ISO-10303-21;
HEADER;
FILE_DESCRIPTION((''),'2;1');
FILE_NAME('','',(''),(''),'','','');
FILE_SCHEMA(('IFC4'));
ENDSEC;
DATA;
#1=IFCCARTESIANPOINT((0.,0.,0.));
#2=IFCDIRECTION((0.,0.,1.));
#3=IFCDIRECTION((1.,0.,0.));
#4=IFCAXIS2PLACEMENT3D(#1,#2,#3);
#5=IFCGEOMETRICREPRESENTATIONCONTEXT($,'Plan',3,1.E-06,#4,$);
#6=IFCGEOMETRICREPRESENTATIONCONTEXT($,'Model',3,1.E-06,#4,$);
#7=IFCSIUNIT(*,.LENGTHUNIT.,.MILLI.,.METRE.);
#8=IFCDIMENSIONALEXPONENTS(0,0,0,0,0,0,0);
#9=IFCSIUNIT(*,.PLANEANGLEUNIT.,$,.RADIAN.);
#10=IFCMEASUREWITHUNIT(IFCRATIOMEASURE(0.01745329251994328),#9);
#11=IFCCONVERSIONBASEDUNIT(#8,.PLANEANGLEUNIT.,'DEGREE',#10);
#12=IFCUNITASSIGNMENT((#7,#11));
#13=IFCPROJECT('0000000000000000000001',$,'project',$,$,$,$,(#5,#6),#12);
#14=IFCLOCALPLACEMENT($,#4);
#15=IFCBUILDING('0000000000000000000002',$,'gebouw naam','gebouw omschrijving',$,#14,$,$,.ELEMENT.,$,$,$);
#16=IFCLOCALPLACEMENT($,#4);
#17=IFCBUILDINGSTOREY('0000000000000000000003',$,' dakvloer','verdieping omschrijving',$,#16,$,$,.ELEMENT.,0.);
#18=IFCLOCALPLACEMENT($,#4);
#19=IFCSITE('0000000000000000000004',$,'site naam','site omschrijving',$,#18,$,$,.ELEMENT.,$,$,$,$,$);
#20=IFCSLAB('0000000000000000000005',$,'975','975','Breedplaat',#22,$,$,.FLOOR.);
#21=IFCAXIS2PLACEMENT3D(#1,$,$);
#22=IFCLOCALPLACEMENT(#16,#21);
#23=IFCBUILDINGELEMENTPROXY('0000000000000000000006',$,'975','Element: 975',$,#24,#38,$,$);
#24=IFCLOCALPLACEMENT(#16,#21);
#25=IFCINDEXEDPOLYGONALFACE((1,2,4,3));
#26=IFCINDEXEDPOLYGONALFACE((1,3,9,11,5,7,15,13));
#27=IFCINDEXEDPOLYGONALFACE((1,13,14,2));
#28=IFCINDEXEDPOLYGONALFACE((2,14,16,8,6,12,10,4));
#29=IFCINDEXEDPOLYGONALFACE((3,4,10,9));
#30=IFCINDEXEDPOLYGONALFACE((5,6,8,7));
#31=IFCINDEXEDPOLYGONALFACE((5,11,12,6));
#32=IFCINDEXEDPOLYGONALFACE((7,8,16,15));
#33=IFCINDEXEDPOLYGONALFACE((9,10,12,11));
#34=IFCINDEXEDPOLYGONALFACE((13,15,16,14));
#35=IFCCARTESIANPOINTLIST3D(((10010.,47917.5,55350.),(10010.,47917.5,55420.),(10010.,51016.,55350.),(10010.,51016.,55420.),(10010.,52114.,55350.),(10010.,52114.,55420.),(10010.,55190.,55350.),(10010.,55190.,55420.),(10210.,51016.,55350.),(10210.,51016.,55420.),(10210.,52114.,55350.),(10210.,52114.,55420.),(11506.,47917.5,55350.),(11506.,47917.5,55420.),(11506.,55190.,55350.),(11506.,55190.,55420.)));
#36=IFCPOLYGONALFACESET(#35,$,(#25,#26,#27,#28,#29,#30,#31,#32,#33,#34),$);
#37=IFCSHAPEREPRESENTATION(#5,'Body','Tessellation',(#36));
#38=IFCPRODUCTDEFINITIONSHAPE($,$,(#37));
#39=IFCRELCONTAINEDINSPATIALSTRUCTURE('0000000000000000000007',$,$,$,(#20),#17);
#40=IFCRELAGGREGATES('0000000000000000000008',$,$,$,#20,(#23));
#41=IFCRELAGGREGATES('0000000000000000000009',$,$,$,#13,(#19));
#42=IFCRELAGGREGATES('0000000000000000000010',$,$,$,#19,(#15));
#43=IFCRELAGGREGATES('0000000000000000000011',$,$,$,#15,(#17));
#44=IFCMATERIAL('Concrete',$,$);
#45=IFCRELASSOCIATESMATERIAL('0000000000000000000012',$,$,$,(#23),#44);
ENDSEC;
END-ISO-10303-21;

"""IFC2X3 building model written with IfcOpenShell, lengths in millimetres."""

from ifc_helpers import new_model, entity, si_unit, converted_unit, frame, origin_with_axes, place, context, project, spatial, polyline, outline, extrude, material, element, aggregate, save


model = new_model("IFC2X3")

# Units and contexts
plan_context = context("Plan", 3, precision=1e-06, world=origin_with_axes())
model_context = context("Model", 3, precision=1e-06, world=origin_with_axes())
ifc_project = project(units=[si_unit("LENGTHUNIT", "METRE", prefix="MILLI"), converted_unit("PLANEANGLEUNIT", "DEGREE", entity("IfcRatioMeasure", 0.01745329251994328), si_unit("PLANEANGLEUNIT", "RADIAN"), dimensions=[0, 0, 0, 0, 0, 0, 0])], contexts=[plan_context, model_context])

# Site, building, storey
site_placement = place(None, origin_with_axes())
site = spatial("IfcSite", under=ifc_project, at=site_placement, Name="site naam", Description="site omschrijving", CompositionType="ELEMENT")
building_placement = place(None, origin_with_axes())
building = spatial("IfcBuilding", under=site, at=building_placement, Name="gebouw naam", Description="gebouw omschrijving", CompositionType="ELEMENT")
storey_placement = place(None, origin_with_axes())
storey = spatial("IfcBuildingStorey", under=building, at=storey_placement, Name=" dakvloer", Description="verdieping omschrijving", CompositionType="ELEMENT", Elevation=0.0)

# Slab, building element proxy, opening
slab_1_placement = place(None, frame((10010.0, 55190.0, 55350.0), z_axis=(0.0, 0.0, 1.0), x_axis=(0.0, -1.0, 0.0)))
slab_1 = element("IfcSlab", 1, at=slab_1_placement, inside=storey, Name="975", Description="975", ObjectType="Breedplaat", PredefinedType="FLOOR")
ifc_material_1 = material(Name="Concrete")
proxy_placement = place(slab_1_placement, origin_with_axes())
proxy = element("IfcBuildingElementProxy", 2, at=proxy_placement, material=ifc_material_1, Name="975", Description="Element: 975", context=plan_context, shape_type="SweptSolid", body=[
    extrude(outline(polyline([(3076.0, 200.0), (4174.0, 200.0), (4174.0, 0.0), (7272.5, 0.0), (7272.5, 1496.0), (0.0, 1496.0), (0.0, 0.0), (3076.0, 0.0), (3076.0, 200.0)])), origin_with_axes(), (0.0, 0.0, 1.0), 70.0),
])
opening_placement = place(None, frame((10010.0, 55190.0, 55350.0), z_axis=(0.0, 0.0, 1.0), x_axis=(0.0, -1.0, 0.0)))
element("IfcOpeningElement", 3, at=opening_placement, cuts=proxy, ObjectType="Opening", context=plan_context, shape_type="SweptSolid", body=[
    extrude(outline(polyline([(-0.1, -0.1), (-0.1, 10.0), (10.0, -0.1), (-0.1, -0.1)])), frame((7273.7, 1496.2, -0.1), z_axis=(-1.0, 0.0, 0.0), x_axis=(0.0, -1.0, 0.0)), (0.0, 0.0, 1.0), 7274.7),
])
aggregate(slab_1, [proxy])

save(model, "model.ifc")
